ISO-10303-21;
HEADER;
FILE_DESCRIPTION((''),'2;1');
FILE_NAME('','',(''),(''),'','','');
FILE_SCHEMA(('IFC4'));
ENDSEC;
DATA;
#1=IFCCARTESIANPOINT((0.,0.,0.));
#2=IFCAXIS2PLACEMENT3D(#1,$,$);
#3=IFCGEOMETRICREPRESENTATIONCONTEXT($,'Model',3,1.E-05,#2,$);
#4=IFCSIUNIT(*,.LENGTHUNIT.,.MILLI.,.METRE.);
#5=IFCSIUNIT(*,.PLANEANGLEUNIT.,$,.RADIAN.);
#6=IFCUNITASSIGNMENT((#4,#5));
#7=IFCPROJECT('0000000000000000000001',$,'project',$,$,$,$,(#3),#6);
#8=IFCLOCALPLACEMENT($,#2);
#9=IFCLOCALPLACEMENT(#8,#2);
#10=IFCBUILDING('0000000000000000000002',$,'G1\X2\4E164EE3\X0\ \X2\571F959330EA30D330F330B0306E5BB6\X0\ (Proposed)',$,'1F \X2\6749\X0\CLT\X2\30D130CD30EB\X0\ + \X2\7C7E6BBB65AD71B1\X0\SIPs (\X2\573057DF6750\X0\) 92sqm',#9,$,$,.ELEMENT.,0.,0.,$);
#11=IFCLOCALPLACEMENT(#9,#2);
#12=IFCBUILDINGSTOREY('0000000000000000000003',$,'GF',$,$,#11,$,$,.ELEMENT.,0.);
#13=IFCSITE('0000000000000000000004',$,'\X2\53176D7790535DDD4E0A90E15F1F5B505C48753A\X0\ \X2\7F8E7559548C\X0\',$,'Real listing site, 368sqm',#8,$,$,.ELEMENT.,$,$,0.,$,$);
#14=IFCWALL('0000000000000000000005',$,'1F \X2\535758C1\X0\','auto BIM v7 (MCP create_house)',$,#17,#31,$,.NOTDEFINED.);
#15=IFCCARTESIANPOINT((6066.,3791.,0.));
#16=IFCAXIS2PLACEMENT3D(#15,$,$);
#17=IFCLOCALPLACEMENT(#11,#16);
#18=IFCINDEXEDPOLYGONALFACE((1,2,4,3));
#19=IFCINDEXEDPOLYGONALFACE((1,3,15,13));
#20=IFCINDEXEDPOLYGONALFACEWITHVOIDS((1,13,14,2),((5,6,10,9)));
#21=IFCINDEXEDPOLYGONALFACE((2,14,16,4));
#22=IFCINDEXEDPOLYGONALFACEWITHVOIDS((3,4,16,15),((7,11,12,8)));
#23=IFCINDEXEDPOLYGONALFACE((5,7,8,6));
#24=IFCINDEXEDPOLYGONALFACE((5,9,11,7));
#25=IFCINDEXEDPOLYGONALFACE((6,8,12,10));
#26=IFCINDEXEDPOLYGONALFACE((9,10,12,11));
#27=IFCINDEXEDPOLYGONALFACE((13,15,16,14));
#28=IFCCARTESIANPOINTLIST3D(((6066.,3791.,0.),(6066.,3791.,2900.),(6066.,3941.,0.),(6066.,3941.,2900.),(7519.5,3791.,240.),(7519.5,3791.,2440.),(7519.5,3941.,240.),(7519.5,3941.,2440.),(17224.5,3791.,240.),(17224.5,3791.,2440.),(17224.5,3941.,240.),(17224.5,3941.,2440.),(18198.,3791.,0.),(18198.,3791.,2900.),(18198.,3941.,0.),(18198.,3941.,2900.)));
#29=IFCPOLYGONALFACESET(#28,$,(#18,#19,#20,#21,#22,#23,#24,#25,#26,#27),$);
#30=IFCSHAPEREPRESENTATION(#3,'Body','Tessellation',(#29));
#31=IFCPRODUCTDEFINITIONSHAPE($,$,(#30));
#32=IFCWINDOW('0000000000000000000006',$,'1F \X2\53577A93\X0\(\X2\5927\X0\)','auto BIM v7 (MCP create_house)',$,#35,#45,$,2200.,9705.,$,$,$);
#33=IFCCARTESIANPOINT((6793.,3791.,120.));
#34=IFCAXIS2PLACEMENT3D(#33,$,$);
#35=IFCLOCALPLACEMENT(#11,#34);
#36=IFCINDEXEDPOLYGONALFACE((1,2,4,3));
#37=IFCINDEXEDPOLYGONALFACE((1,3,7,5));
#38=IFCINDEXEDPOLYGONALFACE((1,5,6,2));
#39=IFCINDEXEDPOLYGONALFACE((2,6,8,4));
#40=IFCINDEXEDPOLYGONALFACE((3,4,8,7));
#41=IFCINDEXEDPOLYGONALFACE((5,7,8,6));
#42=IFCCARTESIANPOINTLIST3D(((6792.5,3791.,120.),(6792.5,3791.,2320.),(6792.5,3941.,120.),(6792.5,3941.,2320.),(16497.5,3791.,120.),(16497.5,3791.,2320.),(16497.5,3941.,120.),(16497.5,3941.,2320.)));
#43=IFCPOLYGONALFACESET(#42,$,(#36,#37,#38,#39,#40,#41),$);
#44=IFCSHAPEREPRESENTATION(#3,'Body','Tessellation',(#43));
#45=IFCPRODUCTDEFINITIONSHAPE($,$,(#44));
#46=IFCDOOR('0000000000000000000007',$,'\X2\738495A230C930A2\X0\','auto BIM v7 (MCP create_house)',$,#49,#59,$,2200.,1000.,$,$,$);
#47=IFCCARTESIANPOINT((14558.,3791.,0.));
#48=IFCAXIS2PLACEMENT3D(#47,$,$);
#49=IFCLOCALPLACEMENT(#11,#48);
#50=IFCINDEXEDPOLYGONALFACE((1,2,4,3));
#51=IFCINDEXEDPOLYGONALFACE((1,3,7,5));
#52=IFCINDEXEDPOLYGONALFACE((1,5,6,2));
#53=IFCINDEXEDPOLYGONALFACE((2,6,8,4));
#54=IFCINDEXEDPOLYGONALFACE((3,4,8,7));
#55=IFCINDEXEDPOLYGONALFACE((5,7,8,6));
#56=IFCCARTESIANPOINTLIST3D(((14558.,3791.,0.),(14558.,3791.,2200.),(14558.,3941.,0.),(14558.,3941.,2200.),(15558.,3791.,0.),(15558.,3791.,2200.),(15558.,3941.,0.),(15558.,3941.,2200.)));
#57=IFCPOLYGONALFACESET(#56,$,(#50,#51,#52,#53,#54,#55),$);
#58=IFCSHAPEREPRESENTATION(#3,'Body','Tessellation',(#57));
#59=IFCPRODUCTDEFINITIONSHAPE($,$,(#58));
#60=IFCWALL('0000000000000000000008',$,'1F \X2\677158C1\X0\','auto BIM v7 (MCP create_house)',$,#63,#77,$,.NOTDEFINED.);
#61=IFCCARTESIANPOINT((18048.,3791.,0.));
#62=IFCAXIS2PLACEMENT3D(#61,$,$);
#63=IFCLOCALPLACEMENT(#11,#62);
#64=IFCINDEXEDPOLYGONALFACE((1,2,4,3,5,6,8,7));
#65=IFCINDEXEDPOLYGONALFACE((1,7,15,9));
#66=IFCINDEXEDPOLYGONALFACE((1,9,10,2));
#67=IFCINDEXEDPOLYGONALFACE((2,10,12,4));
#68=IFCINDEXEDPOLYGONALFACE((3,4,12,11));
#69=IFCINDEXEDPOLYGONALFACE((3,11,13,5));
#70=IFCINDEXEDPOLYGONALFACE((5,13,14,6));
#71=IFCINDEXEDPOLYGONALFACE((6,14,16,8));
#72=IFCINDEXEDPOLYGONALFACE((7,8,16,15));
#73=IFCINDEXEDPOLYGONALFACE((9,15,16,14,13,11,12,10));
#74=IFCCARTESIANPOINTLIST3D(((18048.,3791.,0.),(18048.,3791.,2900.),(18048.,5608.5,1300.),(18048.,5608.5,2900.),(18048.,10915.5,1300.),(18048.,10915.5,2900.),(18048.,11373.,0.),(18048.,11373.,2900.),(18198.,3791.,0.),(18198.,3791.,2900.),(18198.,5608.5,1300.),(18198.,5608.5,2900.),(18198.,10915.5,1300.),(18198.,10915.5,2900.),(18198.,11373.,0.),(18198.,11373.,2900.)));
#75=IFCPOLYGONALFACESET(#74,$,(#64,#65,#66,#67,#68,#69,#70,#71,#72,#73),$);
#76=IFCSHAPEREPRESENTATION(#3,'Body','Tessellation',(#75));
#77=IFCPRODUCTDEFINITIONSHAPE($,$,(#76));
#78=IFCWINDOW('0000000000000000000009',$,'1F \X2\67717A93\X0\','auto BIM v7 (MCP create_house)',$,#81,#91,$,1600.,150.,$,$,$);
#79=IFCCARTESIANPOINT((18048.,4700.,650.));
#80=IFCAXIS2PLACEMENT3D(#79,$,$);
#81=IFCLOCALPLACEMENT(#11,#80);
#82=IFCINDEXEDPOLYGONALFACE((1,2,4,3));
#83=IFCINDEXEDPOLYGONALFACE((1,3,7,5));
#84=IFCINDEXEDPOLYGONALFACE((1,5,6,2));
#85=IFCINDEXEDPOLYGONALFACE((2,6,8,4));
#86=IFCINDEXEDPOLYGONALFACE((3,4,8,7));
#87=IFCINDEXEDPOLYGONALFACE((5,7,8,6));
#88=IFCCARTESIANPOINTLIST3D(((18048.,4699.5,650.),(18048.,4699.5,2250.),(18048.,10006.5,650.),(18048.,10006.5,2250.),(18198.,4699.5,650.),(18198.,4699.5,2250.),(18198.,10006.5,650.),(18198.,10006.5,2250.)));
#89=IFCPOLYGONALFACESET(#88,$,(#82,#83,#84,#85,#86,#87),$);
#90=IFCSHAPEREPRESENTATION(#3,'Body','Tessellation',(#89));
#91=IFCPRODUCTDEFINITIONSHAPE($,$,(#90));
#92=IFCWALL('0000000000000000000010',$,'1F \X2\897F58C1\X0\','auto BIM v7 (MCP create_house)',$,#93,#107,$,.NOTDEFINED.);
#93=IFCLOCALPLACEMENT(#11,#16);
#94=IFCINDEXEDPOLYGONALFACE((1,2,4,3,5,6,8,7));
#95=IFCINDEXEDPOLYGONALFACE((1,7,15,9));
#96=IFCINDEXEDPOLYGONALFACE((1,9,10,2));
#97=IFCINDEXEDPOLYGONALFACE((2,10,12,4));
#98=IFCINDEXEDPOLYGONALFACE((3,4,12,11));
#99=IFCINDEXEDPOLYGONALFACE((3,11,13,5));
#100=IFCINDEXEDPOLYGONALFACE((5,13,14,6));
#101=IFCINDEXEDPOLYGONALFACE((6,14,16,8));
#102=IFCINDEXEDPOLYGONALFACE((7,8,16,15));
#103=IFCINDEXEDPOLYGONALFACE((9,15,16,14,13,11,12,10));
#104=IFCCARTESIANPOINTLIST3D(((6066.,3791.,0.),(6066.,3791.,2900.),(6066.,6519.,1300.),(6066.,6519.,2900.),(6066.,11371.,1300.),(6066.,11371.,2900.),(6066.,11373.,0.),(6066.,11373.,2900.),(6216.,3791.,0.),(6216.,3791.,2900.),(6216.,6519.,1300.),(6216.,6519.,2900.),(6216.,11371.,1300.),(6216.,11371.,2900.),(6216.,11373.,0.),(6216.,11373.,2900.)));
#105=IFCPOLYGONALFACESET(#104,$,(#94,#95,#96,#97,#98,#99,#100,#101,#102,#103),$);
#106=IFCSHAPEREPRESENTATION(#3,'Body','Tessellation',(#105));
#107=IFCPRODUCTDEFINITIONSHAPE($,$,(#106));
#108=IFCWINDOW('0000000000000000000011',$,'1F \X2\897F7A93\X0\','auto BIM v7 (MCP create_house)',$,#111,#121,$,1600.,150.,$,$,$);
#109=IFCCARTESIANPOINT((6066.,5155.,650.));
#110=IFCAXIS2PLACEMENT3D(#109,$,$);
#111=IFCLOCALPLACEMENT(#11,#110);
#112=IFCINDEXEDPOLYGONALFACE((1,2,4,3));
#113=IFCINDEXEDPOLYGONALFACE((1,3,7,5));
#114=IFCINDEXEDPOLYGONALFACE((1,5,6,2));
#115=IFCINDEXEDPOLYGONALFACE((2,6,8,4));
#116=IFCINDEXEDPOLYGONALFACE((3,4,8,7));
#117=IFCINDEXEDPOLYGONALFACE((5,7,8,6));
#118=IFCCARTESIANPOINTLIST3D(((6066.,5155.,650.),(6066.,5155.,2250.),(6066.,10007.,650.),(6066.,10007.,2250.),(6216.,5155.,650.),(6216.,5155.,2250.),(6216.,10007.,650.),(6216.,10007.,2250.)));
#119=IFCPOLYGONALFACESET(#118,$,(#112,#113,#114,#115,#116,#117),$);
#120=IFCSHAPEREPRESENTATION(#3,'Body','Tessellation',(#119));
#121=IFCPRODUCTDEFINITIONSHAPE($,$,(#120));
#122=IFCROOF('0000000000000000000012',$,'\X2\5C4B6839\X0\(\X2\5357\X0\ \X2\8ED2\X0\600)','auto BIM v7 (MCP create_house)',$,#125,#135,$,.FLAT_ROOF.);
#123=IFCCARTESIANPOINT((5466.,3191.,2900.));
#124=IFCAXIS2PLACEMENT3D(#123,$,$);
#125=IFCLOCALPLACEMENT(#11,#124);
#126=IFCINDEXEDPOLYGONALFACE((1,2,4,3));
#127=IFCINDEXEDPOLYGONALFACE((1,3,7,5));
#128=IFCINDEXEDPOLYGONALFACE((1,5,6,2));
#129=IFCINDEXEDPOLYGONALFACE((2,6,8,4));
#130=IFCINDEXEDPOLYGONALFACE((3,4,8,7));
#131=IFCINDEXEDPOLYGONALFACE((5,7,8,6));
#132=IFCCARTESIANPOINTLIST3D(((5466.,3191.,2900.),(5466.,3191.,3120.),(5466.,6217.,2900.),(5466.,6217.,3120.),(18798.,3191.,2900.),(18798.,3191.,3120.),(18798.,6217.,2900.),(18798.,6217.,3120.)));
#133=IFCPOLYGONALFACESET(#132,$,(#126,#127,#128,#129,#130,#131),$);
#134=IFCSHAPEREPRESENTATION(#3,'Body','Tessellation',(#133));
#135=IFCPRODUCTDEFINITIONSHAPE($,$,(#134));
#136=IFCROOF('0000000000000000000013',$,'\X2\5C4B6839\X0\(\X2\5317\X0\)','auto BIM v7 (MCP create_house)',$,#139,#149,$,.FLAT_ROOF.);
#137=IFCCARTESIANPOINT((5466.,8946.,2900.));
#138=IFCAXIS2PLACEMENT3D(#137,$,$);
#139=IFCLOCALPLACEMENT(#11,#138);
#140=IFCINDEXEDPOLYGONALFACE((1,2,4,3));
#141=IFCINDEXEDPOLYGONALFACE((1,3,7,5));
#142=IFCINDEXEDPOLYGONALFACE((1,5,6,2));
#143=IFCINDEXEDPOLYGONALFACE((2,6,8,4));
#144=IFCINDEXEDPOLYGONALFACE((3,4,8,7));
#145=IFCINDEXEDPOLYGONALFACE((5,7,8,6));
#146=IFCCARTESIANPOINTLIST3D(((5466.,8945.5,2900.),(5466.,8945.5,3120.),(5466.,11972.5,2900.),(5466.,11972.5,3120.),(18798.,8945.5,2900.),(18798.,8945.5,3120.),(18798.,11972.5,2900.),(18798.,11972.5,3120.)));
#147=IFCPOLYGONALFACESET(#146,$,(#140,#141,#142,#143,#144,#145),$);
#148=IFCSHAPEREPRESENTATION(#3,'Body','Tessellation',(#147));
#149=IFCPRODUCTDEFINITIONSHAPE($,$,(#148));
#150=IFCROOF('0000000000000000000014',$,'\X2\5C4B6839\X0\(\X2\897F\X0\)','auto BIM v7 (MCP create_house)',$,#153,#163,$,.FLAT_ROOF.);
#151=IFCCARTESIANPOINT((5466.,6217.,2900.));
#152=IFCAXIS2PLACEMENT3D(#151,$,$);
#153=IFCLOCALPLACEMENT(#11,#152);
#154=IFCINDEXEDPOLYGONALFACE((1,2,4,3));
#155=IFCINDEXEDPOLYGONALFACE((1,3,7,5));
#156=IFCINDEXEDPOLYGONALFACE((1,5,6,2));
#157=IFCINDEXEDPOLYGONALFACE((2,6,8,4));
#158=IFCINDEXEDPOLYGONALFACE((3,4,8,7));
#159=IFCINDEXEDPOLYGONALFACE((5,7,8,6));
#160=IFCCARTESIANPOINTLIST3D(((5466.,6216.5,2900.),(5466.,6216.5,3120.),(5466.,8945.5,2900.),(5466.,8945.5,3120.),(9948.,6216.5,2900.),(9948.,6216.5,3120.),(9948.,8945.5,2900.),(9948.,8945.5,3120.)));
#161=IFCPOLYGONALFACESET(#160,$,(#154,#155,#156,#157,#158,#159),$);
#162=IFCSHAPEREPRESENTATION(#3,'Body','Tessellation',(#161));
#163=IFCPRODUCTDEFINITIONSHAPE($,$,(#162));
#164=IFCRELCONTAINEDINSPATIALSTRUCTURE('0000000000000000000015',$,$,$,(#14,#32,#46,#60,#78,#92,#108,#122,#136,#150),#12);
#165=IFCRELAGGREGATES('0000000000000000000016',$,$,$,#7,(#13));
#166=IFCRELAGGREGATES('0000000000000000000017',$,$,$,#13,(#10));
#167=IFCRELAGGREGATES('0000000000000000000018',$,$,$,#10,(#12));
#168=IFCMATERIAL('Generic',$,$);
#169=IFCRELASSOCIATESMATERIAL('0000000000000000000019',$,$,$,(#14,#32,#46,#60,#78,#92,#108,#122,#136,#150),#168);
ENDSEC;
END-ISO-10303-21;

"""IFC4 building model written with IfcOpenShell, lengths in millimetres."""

from ifc_helpers import new_model, si_unit, frame, frame_2d, origin, place, context, project, spatial, rectangle, extrude, material, element, fill, save


model = new_model("IFC4")

# Units and contexts
model_context = context("Model", 3, precision=1e-05, world=origin())
ifc_project = project(units=[si_unit("LENGTHUNIT", "METRE", prefix="MILLI"), si_unit("PLANEANGLEUNIT", "RADIAN")], contexts=[model_context])

# Site, building, storey
site_placement = place(None, origin())
site = spatial("IfcSite", under=ifc_project, at=site_placement, Name="北海道川上郡弟子屈町 美留和", ObjectType="Real listing site, 368sqm", CompositionType="ELEMENT", RefElevation=0.0)
building_placement = place(site_placement, origin())
building = spatial("IfcBuilding", under=site, at=building_placement, Name="G1世代 土間リビングの家 (Proposed)", ObjectType="1F 杉CLTパネル + 籾殻断熱SIPs (地域材) 92sqm", CompositionType="ELEMENT", ElevationOfRefHeight=0.0, ElevationOfTerrain=0.0)
storey_placement = place(building_placement, origin())
storey = spatial("IfcBuildingStorey", under=building, at=storey_placement, Name="GF", CompositionType="ELEMENT", Elevation=0.0)

# Shared definitions
ifc_material = material(Name="Generic")

# Wall, openings, window, door
wall_1_placement = place(storey_placement, frame((6066.0, 3791.0, 0.0)))
wall_1 = element("IfcWall", 1, at=wall_1_placement, inside=storey, material=ifc_material, Name="1F 南壁", Description="auto BIM v7 (MCP create_house)", PredefinedType="NOTDEFINED", context=model_context, shape_type="SweptSolid", body=[
    extrude(rectangle(XDim=12132.0, YDim=150.0, at=frame_2d((6066.0, 75.0))), frame((6066.0, 3791.0, 0.0)), (0.0, 0.0, 1.0), 2900.0),
])
opening_1_placement = place(storey_placement, frame((6793.0, 3791.0, 120.0)))
opening_1 = element("IfcOpeningElement", 2, at=opening_1_placement, cuts=wall_1, PredefinedType="NOTDEFINED", context=model_context, shape_type="SweptSolid", body=[
    extrude(rectangle(XDim=9705.0, YDim=150.0, at=frame_2d((4852.0, 75.0))), frame((6793.0, 3791.0, 120.0)), (0.0, 0.0, 1.0), 2200.0),
])
opening_2_placement = place(storey_placement, frame((14558.0, 3791.0, 0.0)))
opening_2 = element("IfcOpeningElement", 3, at=opening_2_placement, cuts=wall_1, PredefinedType="NOTDEFINED", context=model_context, shape_type="SweptSolid", body=[
    extrude(rectangle(XDim=1000.0, YDim=150.0, at=frame_2d((500.0, 75.0))), frame((14558.0, 3791.0, 0.0)), (0.0, 0.0, 1.0), 2200.0),
])
window_1_placement = place(storey_placement, frame((6793.0, 3791.0, 120.0)))
window_1 = element("IfcWindow", 4, at=window_1_placement, inside=storey, material=ifc_material, Name="1F 南窓(大)", Description="auto BIM v7 (MCP create_house)", OverallHeight=2200.0, OverallWidth=9705.0, context=model_context, shape_type="SweptSolid", body=[
    extrude(rectangle(XDim=9705.0, YDim=150.0, at=frame_2d((4852.0, 75.0))), frame((6793.0, 3791.0, 120.0)), (0.0, 0.0, 1.0), 2200.0),
])
fill(opening_1, window_1)
door_placement = place(storey_placement, frame((14558.0, 3791.0, 0.0)))
door = element("IfcDoor", 5, at=door_placement, inside=storey, material=ifc_material, Name="玄関ドア", Description="auto BIM v7 (MCP create_house)", OverallHeight=2200.0, OverallWidth=1000.0, context=model_context, shape_type="SweptSolid", body=[
    extrude(rectangle(XDim=1000.0, YDim=150.0, at=frame_2d((500.0, 75.0))), frame((14558.0, 3791.0, 0.0)), (0.0, 0.0, 1.0), 2200.0),
])
fill(opening_2, door)

# Walls, openings, windows
wall_2_placement = place(storey_placement, frame((18048.0, 3791.0, 0.0)))
wall_2 = element("IfcWall", 6, at=wall_2_placement, inside=storey, material=ifc_material, Name="1F 東壁", Description="auto BIM v7 (MCP create_house)", PredefinedType="NOTDEFINED", context=model_context, shape_type="SweptSolid", body=[
    extrude(rectangle(XDim=150.0, YDim=7582.0, at=frame_2d((75.0, 3791.0))), frame((18048.0, 3791.0, 0.0)), (0.0, 0.0, 1.0), 2900.0),
])
opening_3_placement = place(storey_placement, frame((18048.0, 4700.0, 650.0)))
opening_3 = element("IfcOpeningElement", 7, at=opening_3_placement, cuts=wall_2, PredefinedType="NOTDEFINED", context=model_context, shape_type="SweptSolid", body=[
    extrude(rectangle(XDim=150.0, YDim=5307.0, at=frame_2d((75.0, 2653.0))), frame((18048.0, 4700.0, 650.0)), (0.0, 0.0, 1.0), 1600.0),
])
window_2_placement = place(storey_placement, frame((18048.0, 4700.0, 650.0)))
window_2 = element("IfcWindow", 8, at=window_2_placement, inside=storey, material=ifc_material, Name="1F 東窓", Description="auto BIM v7 (MCP create_house)", OverallHeight=1600.0, OverallWidth=150.0, context=model_context, shape_type="SweptSolid", body=[
    extrude(rectangle(XDim=150.0, YDim=5307.0, at=frame_2d((75.0, 2653.0))), frame((18048.0, 4700.0, 650.0)), (0.0, 0.0, 1.0), 1600.0),
])
fill(opening_3, window_2)
wall_3_placement = place(storey_placement, frame((6066.0, 3791.0, 0.0)))
wall_3 = element("IfcWall", 9, at=wall_3_placement, inside=storey, material=ifc_material, Name="1F 西壁", Description="auto BIM v7 (MCP create_house)", PredefinedType="NOTDEFINED", context=model_context, shape_type="SweptSolid", body=[
    extrude(rectangle(XDim=150.0, YDim=7582.0, at=frame_2d((75.0, 3791.0))), frame((6066.0, 3791.0, 0.0)), (0.0, 0.0, 1.0), 2900.0),
])
opening_4_placement = place(storey_placement, frame((6066.0, 5155.0, 650.0)))
opening_4 = element("IfcOpeningElement", 10, at=opening_4_placement, cuts=wall_3, PredefinedType="NOTDEFINED", context=model_context, shape_type="SweptSolid", body=[
    extrude(rectangle(XDim=150.0, YDim=4852.0, at=frame_2d((75.0, 2426.0))), frame((6066.0, 5155.0, 650.0)), (0.0, 0.0, 1.0), 1600.0),
])
window_3_placement = place(storey_placement, frame((6066.0, 5155.0, 650.0)))
window_3 = element("IfcWindow", 11, at=window_3_placement, inside=storey, material=ifc_material, Name="1F 西窓", Description="auto BIM v7 (MCP create_house)", OverallHeight=1600.0, OverallWidth=150.0, context=model_context, shape_type="SweptSolid", body=[
    extrude(rectangle(XDim=150.0, YDim=4852.0, at=frame_2d((75.0, 2426.0))), frame((6066.0, 5155.0, 650.0)), (0.0, 0.0, 1.0), 1600.0),
])
fill(opening_4, window_3)

# Roofs
roof_1_placement = place(storey_placement, frame((5466.0, 3191.0, 2900.0)))
element("IfcRoof", 12, at=roof_1_placement, inside=storey, material=ifc_material, Name="屋根(南 軒600)", Description="auto BIM v7 (MCP create_house)", PredefinedType="FLAT_ROOF", context=model_context, shape_type="SweptSolid", body=[
    extrude(rectangle(XDim=13332.0, YDim=3026.0, at=frame_2d((6666.0, 1513.0))), frame((5466.0, 3191.0, 2900.0)), (0.0, 0.0, 1.0), 220.0),
])
roof_2_placement = place(storey_placement, frame((5466.0, 8946.0, 2900.0)))
element("IfcRoof", 13, at=roof_2_placement, inside=storey, material=ifc_material, Name="屋根(北)", Description="auto BIM v7 (MCP create_house)", PredefinedType="FLAT_ROOF", context=model_context, shape_type="SweptSolid", body=[
    extrude(rectangle(XDim=13332.0, YDim=3027.0, at=frame_2d((6666.0, 1513.0))), frame((5466.0, 8946.0, 2900.0)), (0.0, 0.0, 1.0), 220.0),
])
roof_3_placement = place(storey_placement, frame((5466.0, 6217.0, 2900.0)))
element("IfcRoof", 14, at=roof_3_placement, inside=storey, material=ifc_material, Name="屋根(西)", Description="auto BIM v7 (MCP create_house)", PredefinedType="FLAT_ROOF", context=model_context, shape_type="SweptSolid", body=[
    extrude(rectangle(XDim=4482.0, YDim=2729.0, at=frame_2d((2241.0, 1364.0))), frame((5466.0, 6217.0, 2900.0)), (0.0, 0.0, 1.0), 220.0),
])

save(model, "model.ifc")
